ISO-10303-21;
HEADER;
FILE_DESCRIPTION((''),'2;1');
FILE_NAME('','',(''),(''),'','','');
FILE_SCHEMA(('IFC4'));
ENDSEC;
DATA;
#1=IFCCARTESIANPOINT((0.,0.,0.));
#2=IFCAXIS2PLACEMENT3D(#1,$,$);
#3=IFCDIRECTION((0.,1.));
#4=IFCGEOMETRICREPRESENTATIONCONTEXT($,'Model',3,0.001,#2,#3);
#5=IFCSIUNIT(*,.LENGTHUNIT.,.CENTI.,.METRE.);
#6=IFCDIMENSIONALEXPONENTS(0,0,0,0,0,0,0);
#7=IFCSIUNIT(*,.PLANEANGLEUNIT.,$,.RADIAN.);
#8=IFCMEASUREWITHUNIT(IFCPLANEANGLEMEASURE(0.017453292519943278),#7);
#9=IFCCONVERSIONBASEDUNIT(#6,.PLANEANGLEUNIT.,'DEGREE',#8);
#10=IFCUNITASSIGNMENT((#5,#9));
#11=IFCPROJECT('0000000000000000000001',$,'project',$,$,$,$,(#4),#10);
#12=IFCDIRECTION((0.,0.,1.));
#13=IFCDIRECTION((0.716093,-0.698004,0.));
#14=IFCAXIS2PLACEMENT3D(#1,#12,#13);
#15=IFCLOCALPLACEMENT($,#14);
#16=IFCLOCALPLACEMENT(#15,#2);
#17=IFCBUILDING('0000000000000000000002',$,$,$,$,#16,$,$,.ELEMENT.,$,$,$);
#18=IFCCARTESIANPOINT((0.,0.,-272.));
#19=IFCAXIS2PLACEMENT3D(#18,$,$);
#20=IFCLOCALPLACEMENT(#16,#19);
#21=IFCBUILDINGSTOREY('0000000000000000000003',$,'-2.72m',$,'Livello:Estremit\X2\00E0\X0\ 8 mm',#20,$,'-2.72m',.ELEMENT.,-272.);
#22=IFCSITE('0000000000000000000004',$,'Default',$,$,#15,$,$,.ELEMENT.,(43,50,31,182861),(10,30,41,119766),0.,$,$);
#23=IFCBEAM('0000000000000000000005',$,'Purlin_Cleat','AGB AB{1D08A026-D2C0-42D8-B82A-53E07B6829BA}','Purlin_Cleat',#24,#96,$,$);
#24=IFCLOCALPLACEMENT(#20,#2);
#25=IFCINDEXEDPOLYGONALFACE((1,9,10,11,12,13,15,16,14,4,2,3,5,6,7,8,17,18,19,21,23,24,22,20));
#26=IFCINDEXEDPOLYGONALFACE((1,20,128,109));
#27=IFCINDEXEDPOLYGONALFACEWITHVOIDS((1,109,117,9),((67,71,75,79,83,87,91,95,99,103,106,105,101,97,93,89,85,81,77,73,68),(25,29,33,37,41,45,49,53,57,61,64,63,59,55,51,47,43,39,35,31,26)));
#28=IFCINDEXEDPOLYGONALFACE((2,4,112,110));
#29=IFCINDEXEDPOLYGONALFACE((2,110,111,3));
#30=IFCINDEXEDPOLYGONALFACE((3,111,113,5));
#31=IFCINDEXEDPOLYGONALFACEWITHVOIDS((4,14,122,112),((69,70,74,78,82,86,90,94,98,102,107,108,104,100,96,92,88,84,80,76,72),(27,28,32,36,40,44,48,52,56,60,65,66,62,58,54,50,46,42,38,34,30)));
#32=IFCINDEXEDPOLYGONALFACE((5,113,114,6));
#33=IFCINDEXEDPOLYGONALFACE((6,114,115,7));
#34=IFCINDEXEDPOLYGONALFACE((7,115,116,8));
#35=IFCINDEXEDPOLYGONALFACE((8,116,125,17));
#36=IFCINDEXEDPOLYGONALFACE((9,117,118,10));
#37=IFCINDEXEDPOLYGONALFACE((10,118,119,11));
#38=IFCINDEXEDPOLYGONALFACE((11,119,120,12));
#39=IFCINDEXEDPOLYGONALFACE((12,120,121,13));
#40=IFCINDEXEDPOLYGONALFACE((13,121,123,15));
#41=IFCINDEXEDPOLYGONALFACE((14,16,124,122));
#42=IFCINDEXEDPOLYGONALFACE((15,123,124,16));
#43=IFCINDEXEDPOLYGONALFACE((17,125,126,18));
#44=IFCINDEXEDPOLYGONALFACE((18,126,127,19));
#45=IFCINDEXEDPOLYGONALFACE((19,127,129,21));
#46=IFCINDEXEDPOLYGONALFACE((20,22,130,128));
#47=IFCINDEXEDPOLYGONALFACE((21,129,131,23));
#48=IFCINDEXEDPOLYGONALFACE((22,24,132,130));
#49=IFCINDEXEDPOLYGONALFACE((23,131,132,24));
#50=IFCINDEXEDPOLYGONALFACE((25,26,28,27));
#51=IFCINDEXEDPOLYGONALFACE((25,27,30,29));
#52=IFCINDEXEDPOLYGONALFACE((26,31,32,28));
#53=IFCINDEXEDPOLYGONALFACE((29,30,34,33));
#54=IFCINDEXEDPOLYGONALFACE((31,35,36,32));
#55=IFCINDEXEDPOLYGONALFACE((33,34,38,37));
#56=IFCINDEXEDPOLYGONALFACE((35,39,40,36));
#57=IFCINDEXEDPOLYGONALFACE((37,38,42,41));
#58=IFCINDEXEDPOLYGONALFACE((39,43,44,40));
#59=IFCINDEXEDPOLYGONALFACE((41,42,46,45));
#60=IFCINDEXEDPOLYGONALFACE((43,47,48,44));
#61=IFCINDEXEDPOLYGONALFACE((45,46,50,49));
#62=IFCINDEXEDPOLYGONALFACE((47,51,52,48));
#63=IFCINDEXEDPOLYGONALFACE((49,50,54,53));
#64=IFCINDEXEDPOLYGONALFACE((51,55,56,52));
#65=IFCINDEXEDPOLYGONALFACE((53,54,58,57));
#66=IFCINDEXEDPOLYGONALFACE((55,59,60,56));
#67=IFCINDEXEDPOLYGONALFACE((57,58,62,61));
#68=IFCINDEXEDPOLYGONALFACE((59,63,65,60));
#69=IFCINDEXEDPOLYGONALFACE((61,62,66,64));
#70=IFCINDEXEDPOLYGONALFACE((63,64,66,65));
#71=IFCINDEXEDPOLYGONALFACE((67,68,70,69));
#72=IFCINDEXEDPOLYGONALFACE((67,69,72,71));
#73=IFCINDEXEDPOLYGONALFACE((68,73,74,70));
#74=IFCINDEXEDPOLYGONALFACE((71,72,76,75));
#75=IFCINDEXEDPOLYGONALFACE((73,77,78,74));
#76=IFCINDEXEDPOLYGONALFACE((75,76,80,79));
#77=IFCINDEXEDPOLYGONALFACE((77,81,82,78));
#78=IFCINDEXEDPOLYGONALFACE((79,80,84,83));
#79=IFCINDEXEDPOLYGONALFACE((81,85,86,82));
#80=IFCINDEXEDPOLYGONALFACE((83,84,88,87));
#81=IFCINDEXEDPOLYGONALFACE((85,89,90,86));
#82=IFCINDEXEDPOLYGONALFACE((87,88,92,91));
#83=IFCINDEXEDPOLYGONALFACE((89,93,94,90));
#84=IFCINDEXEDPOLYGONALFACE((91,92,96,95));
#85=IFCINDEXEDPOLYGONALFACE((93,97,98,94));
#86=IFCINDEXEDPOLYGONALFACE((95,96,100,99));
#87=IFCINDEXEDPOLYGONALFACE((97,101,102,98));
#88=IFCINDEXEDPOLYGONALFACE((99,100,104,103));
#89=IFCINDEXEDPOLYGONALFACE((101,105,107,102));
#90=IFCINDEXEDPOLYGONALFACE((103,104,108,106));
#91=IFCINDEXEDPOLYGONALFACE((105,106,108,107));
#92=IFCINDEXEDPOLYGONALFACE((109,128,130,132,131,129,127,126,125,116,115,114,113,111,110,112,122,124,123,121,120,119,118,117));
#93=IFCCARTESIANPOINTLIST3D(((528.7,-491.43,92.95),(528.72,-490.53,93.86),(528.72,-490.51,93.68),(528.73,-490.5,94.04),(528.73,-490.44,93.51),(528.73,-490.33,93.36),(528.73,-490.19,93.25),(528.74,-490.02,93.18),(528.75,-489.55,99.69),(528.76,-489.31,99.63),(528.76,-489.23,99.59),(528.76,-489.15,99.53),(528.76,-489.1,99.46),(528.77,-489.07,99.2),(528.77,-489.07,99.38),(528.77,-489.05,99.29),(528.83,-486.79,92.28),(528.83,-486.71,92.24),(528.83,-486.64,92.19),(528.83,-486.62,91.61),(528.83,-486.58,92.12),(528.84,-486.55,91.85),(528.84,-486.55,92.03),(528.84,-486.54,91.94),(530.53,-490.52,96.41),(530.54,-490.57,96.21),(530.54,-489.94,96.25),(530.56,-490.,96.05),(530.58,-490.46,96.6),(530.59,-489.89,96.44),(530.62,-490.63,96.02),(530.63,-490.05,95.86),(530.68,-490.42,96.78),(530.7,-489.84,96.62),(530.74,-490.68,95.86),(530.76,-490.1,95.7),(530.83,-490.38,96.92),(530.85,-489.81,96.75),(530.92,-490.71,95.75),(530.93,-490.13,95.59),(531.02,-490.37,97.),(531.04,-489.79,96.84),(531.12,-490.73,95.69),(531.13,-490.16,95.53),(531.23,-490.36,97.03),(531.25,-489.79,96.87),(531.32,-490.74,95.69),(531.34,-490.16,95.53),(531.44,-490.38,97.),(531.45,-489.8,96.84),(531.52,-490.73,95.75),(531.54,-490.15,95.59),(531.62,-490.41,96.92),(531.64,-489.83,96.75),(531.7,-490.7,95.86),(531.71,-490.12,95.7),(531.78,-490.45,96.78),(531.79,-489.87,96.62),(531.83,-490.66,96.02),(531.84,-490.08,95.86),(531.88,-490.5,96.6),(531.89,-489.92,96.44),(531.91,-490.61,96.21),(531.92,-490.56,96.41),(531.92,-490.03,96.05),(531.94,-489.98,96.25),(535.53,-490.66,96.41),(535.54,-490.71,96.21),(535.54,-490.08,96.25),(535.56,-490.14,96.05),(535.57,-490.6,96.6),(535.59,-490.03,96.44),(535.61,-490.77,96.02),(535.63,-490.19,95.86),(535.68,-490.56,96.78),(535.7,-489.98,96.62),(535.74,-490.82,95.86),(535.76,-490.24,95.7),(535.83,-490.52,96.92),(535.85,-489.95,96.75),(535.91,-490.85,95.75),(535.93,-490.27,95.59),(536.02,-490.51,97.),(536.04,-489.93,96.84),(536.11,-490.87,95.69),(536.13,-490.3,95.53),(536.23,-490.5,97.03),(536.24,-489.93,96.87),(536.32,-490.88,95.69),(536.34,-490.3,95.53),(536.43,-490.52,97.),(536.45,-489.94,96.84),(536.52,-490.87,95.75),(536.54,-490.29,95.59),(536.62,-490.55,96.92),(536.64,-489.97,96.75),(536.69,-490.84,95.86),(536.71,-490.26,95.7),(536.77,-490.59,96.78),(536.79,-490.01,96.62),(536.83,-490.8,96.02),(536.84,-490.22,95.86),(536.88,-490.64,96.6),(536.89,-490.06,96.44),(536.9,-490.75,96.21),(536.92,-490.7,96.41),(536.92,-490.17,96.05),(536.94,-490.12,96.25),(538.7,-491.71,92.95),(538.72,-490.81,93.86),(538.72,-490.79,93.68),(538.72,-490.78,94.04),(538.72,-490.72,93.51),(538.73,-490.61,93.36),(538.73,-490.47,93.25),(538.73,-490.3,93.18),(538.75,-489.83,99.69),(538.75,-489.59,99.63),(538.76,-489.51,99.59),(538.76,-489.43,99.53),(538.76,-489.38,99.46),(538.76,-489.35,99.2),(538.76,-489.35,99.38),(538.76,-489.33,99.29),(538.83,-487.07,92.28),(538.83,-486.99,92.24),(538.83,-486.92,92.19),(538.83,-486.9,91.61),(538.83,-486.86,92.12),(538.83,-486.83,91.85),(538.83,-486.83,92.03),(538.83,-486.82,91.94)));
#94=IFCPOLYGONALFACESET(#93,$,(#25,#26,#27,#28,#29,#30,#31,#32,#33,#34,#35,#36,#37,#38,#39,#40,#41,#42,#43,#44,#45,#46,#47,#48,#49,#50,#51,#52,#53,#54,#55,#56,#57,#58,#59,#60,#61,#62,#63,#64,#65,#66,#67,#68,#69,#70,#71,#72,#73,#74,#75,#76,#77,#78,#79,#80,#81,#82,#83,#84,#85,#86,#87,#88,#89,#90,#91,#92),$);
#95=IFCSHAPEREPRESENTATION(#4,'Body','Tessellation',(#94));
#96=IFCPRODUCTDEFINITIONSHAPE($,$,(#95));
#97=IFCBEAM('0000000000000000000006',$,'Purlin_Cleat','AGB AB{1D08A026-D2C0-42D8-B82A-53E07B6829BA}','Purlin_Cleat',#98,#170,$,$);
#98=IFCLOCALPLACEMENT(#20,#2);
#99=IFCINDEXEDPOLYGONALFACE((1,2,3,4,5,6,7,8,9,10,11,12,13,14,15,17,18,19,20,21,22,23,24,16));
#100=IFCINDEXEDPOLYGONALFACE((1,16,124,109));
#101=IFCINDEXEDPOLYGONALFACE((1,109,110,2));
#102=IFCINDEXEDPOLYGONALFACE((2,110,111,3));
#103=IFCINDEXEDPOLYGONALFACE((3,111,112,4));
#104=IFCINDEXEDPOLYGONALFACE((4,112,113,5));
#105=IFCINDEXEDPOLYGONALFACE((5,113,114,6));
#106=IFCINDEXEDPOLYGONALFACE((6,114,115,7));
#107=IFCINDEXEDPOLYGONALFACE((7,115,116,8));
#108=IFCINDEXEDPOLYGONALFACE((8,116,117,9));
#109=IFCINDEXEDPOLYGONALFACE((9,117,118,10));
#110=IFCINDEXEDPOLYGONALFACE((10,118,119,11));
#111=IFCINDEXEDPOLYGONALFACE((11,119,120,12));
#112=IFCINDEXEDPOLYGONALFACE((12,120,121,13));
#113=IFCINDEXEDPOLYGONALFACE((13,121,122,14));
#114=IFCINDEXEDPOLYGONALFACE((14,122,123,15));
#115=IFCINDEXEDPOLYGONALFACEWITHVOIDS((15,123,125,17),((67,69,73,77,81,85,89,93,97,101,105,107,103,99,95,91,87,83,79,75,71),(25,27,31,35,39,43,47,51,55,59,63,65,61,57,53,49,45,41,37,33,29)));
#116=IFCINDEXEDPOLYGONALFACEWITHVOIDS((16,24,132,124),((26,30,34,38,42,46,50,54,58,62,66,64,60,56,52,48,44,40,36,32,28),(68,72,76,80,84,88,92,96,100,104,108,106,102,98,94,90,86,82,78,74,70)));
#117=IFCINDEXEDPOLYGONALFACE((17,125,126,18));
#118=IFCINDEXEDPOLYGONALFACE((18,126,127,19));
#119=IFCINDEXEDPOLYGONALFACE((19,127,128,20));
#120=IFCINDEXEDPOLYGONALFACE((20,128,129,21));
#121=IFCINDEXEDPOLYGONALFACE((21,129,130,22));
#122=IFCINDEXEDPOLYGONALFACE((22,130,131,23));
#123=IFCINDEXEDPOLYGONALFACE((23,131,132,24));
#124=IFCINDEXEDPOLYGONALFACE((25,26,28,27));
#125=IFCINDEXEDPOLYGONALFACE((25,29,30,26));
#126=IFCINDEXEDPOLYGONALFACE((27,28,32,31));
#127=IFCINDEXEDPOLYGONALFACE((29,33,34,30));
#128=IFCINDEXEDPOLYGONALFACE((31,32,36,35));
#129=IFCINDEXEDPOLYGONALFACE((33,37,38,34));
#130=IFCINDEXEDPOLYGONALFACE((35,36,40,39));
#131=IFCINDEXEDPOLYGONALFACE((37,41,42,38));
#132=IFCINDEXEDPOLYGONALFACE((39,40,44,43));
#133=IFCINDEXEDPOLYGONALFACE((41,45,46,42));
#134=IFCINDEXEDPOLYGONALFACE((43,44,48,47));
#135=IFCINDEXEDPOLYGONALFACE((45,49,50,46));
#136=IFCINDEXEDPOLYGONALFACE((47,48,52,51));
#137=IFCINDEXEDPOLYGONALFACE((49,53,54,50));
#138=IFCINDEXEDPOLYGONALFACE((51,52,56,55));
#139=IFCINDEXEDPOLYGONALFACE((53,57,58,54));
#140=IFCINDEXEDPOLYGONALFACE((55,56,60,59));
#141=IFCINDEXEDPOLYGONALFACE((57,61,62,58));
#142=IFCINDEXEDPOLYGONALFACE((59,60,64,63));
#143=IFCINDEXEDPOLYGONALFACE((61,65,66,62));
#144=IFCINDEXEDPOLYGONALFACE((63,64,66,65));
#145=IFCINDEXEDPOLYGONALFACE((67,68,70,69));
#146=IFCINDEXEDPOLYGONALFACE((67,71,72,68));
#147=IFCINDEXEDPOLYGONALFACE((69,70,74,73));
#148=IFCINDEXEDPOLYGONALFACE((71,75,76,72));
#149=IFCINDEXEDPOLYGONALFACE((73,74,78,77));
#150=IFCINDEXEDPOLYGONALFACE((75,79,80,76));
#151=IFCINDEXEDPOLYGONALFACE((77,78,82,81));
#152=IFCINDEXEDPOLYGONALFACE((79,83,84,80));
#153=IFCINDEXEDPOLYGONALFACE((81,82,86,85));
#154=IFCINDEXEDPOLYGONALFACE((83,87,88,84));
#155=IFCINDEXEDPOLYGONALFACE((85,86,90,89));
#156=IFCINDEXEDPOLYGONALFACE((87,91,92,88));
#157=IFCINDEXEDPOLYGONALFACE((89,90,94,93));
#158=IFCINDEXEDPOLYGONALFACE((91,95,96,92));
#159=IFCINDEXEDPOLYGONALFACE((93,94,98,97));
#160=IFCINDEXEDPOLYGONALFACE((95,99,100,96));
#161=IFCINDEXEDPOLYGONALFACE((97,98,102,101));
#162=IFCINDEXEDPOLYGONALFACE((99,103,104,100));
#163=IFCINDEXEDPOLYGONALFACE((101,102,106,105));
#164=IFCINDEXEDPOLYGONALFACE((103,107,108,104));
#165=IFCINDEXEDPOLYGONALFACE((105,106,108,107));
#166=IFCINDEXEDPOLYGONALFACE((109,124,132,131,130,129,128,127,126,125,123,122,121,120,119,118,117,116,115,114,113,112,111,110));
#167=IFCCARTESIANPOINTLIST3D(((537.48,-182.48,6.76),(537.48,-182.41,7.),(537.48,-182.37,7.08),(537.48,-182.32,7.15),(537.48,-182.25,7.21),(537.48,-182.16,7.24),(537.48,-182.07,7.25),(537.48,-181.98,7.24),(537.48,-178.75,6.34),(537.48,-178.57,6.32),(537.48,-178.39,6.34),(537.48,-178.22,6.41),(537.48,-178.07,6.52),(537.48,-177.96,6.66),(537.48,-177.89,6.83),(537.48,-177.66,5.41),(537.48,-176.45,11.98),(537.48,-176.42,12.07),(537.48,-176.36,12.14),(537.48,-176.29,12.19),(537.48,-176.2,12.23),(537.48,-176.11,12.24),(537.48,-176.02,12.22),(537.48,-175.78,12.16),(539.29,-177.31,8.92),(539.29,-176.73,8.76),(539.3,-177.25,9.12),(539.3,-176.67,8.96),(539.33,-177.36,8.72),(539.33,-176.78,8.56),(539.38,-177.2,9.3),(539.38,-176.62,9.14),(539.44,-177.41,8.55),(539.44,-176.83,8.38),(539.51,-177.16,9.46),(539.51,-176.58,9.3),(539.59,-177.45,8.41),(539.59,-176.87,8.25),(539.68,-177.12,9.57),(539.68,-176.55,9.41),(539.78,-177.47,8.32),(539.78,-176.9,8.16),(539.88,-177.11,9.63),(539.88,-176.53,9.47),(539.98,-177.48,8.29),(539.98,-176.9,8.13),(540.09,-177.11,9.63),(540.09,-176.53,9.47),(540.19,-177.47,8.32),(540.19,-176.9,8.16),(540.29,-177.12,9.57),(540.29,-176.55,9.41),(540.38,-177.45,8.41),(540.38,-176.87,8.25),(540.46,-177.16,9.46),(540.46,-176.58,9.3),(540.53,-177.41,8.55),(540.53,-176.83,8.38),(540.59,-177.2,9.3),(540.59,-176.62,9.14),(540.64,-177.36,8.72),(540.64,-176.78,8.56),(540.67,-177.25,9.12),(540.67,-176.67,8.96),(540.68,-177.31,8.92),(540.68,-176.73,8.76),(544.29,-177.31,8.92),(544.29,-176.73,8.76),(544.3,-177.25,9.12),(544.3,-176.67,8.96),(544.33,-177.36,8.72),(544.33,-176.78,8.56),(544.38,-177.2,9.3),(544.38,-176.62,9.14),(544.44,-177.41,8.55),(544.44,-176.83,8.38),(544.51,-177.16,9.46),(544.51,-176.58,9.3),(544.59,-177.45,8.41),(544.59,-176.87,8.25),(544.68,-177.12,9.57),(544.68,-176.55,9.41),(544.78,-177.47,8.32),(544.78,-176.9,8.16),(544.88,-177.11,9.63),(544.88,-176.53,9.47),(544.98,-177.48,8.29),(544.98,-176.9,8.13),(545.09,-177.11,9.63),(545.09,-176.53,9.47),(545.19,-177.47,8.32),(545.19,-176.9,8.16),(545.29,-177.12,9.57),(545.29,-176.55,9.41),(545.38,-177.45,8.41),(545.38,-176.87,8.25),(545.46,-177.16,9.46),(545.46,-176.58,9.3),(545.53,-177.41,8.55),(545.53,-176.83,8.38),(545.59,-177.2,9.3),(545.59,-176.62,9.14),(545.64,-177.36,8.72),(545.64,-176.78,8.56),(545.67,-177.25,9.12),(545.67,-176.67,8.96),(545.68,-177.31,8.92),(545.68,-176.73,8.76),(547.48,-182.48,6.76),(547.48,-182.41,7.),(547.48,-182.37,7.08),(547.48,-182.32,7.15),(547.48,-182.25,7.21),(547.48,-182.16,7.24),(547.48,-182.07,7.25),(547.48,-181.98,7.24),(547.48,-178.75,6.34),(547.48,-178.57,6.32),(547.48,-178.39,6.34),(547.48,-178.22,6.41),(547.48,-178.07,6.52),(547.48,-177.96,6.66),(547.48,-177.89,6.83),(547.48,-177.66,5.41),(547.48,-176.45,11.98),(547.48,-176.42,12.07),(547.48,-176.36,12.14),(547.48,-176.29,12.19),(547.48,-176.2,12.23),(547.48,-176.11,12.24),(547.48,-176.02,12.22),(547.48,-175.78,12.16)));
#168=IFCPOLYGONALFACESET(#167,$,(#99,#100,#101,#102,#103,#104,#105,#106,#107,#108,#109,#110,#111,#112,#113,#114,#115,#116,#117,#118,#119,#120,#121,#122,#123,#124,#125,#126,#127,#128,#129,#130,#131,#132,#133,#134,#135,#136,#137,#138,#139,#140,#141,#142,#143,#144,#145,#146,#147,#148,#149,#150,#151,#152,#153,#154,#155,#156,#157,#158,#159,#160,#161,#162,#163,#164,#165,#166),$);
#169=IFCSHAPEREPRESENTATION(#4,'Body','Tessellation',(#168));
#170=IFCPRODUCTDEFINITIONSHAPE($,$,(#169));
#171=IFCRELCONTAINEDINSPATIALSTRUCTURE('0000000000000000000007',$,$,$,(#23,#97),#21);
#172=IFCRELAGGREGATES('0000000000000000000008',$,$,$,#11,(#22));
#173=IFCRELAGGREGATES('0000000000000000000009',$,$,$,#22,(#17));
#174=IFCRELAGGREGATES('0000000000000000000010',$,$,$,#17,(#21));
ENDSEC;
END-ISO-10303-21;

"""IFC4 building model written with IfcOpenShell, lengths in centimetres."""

from ifc_helpers import new_model, entity, si_unit, converted_unit, direction, frame, frame_2d, origin, place, context, project, spatial, circle, l_section, extrude, element, save


model = new_model("IFC4")

# Units and contexts
model_context = context("Model", 3, precision=0.001, world=origin(), true_north=direction((0.0, 1.0)))
ifc_project = project(units=[si_unit("LENGTHUNIT", "METRE", prefix="CENTI"), converted_unit("PLANEANGLEUNIT", "DEGREE", entity("IfcPlaneAngleMeasure", 0.017453292519943278), si_unit("PLANEANGLEUNIT", "RADIAN"), dimensions=[0, 0, 0, 0, 0, 0, 0])], contexts=[model_context])

# Site, building, storey
site_placement = place(None, frame((0.0, 0.0, 0.0), z_axis=(0.0, 0.0, 1.0), x_axis=(0.716093, -0.698004, 0.0)))
site = spatial("IfcSite", under=ifc_project, at=site_placement, Name="Default", CompositionType="ELEMENT", RefLatitude=(43, 50, 31, 182861), RefLongitude=(10, 30, 41, 119766), RefElevation=0.0)
building_placement = place(site_placement, origin())
building = spatial("IfcBuilding", under=site, at=building_placement, CompositionType="ELEMENT")
storey_placement = place(building_placement, frame((0.0, 0.0, -272.0)))
storey = spatial("IfcBuildingStorey", under=building, at=storey_placement, Name="-2.72m", ObjectType="Livello:Estremità 8 mm", LongName="-2.72m", CompositionType="ELEMENT", Elevation=-272.0)

# Beams, openings
beam_1_placement = place(storey_placement, frame((538.75, -489.92, 94.79), z_axis=(-0.999608, 0.02798, 0.0), x_axis=(0.007515, 0.268478, 0.963256)))
beam_1 = element("IfcBeam", 1, at=beam_1_placement, inside=storey, Name="Purlin_Cleat", Description="AGB AB{1D08A026-D2C0-42D8-B82A-53E07B6829BA}", ObjectType="Purlin_Cleat", context=model_context, shape_type="SweptSolid", body=[
    extrude(l_section(Depth=5.0, Width=7.0, Thickness=0.6, FilletRadius=0.7, EdgeRadius=0.35, at=frame_2d((1.25, 1.27))), origin(), (0.0, 0.0, 1.0), 10.0),
])
opening_1_placement = place(beam_1_placement, frame((1.29, -1.3, 6.8), z_axis=(0.0, -1.0, 0.0), x_axis=(1.0, 0.0, 0.0)))
element("IfcOpeningElement", 2, at=opening_1_placement, cuts=beam_1, ObjectType="Opening", context=model_context, shape_type="SweptSolid", body=[
    extrude(circle(Radius=0.7, at=frame_2d((0.0, 0.7), x_axis=(1.0, 0.0))), origin(), (0.0, 0.0, -1.0), 0.7),
])
opening_2_placement = place(beam_1_placement, frame((1.29, -1.3, 1.8), z_axis=(0.0, -1.0, 0.0), x_axis=(1.0, 0.0, 0.0)))
element("IfcOpeningElement", 3, at=opening_2_placement, cuts=beam_1, ObjectType="Opening", context=model_context, shape_type="SweptSolid", body=[
    extrude(circle(Radius=0.7, at=frame_2d((0.0, 0.7), x_axis=(1.0, 0.0))), origin(), (0.0, 0.0, -1.0), 0.7),
])
beam_2_placement = place(storey_placement, frame((547.48, -178.24, 7.91), z_axis=(1.0, 0.0, 0.0), x_axis=(0.0, 0.268584, 0.963256)))
beam_2 = element("IfcBeam", 4, at=beam_2_placement, inside=storey, Name="Purlin_Cleat", Description="AGB AB{1D08A026-D2C0-42D8-B82A-53E07B6829BA}", ObjectType="Purlin_Cleat", context=model_context, shape_type="SweptSolid", body=[
    extrude(l_section(Depth=5.0, Width=7.0, Thickness=0.6, FilletRadius=0.7, EdgeRadius=0.35, at=frame_2d((1.25, 1.27))), origin(), (0.0, 0.0, -1.0), 10.0),
])
opening_3_placement = place(beam_2_placement, frame((1.27, -0.6, -3.2), z_axis=(0.0, 1.0, 0.0), x_axis=(-1.0, 0.0, 0.0)))
element("IfcOpeningElement", 5, at=opening_3_placement, cuts=beam_2, ObjectType="Opening", context=model_context, shape_type="SweptSolid", body=[
    extrude(circle(Radius=0.7, at=frame_2d((0.0, 0.7), x_axis=(1.0, 0.0))), origin(), (0.0, 0.0, -1.0), 0.7),
])
opening_4_placement = place(beam_2_placement, frame((1.27, -0.6, -8.2), z_axis=(0.0, 1.0, 0.0), x_axis=(-1.0, 0.0, 0.0)))
element("IfcOpeningElement", 6, at=opening_4_placement, cuts=beam_2, ObjectType="Opening", context=model_context, shape_type="SweptSolid", body=[
    extrude(circle(Radius=0.7, at=frame_2d((0.0, 0.7), x_axis=(1.0, 0.0))), origin(), (0.0, 0.0, -1.0), 0.7),
])

save(model, "model.ifc")
